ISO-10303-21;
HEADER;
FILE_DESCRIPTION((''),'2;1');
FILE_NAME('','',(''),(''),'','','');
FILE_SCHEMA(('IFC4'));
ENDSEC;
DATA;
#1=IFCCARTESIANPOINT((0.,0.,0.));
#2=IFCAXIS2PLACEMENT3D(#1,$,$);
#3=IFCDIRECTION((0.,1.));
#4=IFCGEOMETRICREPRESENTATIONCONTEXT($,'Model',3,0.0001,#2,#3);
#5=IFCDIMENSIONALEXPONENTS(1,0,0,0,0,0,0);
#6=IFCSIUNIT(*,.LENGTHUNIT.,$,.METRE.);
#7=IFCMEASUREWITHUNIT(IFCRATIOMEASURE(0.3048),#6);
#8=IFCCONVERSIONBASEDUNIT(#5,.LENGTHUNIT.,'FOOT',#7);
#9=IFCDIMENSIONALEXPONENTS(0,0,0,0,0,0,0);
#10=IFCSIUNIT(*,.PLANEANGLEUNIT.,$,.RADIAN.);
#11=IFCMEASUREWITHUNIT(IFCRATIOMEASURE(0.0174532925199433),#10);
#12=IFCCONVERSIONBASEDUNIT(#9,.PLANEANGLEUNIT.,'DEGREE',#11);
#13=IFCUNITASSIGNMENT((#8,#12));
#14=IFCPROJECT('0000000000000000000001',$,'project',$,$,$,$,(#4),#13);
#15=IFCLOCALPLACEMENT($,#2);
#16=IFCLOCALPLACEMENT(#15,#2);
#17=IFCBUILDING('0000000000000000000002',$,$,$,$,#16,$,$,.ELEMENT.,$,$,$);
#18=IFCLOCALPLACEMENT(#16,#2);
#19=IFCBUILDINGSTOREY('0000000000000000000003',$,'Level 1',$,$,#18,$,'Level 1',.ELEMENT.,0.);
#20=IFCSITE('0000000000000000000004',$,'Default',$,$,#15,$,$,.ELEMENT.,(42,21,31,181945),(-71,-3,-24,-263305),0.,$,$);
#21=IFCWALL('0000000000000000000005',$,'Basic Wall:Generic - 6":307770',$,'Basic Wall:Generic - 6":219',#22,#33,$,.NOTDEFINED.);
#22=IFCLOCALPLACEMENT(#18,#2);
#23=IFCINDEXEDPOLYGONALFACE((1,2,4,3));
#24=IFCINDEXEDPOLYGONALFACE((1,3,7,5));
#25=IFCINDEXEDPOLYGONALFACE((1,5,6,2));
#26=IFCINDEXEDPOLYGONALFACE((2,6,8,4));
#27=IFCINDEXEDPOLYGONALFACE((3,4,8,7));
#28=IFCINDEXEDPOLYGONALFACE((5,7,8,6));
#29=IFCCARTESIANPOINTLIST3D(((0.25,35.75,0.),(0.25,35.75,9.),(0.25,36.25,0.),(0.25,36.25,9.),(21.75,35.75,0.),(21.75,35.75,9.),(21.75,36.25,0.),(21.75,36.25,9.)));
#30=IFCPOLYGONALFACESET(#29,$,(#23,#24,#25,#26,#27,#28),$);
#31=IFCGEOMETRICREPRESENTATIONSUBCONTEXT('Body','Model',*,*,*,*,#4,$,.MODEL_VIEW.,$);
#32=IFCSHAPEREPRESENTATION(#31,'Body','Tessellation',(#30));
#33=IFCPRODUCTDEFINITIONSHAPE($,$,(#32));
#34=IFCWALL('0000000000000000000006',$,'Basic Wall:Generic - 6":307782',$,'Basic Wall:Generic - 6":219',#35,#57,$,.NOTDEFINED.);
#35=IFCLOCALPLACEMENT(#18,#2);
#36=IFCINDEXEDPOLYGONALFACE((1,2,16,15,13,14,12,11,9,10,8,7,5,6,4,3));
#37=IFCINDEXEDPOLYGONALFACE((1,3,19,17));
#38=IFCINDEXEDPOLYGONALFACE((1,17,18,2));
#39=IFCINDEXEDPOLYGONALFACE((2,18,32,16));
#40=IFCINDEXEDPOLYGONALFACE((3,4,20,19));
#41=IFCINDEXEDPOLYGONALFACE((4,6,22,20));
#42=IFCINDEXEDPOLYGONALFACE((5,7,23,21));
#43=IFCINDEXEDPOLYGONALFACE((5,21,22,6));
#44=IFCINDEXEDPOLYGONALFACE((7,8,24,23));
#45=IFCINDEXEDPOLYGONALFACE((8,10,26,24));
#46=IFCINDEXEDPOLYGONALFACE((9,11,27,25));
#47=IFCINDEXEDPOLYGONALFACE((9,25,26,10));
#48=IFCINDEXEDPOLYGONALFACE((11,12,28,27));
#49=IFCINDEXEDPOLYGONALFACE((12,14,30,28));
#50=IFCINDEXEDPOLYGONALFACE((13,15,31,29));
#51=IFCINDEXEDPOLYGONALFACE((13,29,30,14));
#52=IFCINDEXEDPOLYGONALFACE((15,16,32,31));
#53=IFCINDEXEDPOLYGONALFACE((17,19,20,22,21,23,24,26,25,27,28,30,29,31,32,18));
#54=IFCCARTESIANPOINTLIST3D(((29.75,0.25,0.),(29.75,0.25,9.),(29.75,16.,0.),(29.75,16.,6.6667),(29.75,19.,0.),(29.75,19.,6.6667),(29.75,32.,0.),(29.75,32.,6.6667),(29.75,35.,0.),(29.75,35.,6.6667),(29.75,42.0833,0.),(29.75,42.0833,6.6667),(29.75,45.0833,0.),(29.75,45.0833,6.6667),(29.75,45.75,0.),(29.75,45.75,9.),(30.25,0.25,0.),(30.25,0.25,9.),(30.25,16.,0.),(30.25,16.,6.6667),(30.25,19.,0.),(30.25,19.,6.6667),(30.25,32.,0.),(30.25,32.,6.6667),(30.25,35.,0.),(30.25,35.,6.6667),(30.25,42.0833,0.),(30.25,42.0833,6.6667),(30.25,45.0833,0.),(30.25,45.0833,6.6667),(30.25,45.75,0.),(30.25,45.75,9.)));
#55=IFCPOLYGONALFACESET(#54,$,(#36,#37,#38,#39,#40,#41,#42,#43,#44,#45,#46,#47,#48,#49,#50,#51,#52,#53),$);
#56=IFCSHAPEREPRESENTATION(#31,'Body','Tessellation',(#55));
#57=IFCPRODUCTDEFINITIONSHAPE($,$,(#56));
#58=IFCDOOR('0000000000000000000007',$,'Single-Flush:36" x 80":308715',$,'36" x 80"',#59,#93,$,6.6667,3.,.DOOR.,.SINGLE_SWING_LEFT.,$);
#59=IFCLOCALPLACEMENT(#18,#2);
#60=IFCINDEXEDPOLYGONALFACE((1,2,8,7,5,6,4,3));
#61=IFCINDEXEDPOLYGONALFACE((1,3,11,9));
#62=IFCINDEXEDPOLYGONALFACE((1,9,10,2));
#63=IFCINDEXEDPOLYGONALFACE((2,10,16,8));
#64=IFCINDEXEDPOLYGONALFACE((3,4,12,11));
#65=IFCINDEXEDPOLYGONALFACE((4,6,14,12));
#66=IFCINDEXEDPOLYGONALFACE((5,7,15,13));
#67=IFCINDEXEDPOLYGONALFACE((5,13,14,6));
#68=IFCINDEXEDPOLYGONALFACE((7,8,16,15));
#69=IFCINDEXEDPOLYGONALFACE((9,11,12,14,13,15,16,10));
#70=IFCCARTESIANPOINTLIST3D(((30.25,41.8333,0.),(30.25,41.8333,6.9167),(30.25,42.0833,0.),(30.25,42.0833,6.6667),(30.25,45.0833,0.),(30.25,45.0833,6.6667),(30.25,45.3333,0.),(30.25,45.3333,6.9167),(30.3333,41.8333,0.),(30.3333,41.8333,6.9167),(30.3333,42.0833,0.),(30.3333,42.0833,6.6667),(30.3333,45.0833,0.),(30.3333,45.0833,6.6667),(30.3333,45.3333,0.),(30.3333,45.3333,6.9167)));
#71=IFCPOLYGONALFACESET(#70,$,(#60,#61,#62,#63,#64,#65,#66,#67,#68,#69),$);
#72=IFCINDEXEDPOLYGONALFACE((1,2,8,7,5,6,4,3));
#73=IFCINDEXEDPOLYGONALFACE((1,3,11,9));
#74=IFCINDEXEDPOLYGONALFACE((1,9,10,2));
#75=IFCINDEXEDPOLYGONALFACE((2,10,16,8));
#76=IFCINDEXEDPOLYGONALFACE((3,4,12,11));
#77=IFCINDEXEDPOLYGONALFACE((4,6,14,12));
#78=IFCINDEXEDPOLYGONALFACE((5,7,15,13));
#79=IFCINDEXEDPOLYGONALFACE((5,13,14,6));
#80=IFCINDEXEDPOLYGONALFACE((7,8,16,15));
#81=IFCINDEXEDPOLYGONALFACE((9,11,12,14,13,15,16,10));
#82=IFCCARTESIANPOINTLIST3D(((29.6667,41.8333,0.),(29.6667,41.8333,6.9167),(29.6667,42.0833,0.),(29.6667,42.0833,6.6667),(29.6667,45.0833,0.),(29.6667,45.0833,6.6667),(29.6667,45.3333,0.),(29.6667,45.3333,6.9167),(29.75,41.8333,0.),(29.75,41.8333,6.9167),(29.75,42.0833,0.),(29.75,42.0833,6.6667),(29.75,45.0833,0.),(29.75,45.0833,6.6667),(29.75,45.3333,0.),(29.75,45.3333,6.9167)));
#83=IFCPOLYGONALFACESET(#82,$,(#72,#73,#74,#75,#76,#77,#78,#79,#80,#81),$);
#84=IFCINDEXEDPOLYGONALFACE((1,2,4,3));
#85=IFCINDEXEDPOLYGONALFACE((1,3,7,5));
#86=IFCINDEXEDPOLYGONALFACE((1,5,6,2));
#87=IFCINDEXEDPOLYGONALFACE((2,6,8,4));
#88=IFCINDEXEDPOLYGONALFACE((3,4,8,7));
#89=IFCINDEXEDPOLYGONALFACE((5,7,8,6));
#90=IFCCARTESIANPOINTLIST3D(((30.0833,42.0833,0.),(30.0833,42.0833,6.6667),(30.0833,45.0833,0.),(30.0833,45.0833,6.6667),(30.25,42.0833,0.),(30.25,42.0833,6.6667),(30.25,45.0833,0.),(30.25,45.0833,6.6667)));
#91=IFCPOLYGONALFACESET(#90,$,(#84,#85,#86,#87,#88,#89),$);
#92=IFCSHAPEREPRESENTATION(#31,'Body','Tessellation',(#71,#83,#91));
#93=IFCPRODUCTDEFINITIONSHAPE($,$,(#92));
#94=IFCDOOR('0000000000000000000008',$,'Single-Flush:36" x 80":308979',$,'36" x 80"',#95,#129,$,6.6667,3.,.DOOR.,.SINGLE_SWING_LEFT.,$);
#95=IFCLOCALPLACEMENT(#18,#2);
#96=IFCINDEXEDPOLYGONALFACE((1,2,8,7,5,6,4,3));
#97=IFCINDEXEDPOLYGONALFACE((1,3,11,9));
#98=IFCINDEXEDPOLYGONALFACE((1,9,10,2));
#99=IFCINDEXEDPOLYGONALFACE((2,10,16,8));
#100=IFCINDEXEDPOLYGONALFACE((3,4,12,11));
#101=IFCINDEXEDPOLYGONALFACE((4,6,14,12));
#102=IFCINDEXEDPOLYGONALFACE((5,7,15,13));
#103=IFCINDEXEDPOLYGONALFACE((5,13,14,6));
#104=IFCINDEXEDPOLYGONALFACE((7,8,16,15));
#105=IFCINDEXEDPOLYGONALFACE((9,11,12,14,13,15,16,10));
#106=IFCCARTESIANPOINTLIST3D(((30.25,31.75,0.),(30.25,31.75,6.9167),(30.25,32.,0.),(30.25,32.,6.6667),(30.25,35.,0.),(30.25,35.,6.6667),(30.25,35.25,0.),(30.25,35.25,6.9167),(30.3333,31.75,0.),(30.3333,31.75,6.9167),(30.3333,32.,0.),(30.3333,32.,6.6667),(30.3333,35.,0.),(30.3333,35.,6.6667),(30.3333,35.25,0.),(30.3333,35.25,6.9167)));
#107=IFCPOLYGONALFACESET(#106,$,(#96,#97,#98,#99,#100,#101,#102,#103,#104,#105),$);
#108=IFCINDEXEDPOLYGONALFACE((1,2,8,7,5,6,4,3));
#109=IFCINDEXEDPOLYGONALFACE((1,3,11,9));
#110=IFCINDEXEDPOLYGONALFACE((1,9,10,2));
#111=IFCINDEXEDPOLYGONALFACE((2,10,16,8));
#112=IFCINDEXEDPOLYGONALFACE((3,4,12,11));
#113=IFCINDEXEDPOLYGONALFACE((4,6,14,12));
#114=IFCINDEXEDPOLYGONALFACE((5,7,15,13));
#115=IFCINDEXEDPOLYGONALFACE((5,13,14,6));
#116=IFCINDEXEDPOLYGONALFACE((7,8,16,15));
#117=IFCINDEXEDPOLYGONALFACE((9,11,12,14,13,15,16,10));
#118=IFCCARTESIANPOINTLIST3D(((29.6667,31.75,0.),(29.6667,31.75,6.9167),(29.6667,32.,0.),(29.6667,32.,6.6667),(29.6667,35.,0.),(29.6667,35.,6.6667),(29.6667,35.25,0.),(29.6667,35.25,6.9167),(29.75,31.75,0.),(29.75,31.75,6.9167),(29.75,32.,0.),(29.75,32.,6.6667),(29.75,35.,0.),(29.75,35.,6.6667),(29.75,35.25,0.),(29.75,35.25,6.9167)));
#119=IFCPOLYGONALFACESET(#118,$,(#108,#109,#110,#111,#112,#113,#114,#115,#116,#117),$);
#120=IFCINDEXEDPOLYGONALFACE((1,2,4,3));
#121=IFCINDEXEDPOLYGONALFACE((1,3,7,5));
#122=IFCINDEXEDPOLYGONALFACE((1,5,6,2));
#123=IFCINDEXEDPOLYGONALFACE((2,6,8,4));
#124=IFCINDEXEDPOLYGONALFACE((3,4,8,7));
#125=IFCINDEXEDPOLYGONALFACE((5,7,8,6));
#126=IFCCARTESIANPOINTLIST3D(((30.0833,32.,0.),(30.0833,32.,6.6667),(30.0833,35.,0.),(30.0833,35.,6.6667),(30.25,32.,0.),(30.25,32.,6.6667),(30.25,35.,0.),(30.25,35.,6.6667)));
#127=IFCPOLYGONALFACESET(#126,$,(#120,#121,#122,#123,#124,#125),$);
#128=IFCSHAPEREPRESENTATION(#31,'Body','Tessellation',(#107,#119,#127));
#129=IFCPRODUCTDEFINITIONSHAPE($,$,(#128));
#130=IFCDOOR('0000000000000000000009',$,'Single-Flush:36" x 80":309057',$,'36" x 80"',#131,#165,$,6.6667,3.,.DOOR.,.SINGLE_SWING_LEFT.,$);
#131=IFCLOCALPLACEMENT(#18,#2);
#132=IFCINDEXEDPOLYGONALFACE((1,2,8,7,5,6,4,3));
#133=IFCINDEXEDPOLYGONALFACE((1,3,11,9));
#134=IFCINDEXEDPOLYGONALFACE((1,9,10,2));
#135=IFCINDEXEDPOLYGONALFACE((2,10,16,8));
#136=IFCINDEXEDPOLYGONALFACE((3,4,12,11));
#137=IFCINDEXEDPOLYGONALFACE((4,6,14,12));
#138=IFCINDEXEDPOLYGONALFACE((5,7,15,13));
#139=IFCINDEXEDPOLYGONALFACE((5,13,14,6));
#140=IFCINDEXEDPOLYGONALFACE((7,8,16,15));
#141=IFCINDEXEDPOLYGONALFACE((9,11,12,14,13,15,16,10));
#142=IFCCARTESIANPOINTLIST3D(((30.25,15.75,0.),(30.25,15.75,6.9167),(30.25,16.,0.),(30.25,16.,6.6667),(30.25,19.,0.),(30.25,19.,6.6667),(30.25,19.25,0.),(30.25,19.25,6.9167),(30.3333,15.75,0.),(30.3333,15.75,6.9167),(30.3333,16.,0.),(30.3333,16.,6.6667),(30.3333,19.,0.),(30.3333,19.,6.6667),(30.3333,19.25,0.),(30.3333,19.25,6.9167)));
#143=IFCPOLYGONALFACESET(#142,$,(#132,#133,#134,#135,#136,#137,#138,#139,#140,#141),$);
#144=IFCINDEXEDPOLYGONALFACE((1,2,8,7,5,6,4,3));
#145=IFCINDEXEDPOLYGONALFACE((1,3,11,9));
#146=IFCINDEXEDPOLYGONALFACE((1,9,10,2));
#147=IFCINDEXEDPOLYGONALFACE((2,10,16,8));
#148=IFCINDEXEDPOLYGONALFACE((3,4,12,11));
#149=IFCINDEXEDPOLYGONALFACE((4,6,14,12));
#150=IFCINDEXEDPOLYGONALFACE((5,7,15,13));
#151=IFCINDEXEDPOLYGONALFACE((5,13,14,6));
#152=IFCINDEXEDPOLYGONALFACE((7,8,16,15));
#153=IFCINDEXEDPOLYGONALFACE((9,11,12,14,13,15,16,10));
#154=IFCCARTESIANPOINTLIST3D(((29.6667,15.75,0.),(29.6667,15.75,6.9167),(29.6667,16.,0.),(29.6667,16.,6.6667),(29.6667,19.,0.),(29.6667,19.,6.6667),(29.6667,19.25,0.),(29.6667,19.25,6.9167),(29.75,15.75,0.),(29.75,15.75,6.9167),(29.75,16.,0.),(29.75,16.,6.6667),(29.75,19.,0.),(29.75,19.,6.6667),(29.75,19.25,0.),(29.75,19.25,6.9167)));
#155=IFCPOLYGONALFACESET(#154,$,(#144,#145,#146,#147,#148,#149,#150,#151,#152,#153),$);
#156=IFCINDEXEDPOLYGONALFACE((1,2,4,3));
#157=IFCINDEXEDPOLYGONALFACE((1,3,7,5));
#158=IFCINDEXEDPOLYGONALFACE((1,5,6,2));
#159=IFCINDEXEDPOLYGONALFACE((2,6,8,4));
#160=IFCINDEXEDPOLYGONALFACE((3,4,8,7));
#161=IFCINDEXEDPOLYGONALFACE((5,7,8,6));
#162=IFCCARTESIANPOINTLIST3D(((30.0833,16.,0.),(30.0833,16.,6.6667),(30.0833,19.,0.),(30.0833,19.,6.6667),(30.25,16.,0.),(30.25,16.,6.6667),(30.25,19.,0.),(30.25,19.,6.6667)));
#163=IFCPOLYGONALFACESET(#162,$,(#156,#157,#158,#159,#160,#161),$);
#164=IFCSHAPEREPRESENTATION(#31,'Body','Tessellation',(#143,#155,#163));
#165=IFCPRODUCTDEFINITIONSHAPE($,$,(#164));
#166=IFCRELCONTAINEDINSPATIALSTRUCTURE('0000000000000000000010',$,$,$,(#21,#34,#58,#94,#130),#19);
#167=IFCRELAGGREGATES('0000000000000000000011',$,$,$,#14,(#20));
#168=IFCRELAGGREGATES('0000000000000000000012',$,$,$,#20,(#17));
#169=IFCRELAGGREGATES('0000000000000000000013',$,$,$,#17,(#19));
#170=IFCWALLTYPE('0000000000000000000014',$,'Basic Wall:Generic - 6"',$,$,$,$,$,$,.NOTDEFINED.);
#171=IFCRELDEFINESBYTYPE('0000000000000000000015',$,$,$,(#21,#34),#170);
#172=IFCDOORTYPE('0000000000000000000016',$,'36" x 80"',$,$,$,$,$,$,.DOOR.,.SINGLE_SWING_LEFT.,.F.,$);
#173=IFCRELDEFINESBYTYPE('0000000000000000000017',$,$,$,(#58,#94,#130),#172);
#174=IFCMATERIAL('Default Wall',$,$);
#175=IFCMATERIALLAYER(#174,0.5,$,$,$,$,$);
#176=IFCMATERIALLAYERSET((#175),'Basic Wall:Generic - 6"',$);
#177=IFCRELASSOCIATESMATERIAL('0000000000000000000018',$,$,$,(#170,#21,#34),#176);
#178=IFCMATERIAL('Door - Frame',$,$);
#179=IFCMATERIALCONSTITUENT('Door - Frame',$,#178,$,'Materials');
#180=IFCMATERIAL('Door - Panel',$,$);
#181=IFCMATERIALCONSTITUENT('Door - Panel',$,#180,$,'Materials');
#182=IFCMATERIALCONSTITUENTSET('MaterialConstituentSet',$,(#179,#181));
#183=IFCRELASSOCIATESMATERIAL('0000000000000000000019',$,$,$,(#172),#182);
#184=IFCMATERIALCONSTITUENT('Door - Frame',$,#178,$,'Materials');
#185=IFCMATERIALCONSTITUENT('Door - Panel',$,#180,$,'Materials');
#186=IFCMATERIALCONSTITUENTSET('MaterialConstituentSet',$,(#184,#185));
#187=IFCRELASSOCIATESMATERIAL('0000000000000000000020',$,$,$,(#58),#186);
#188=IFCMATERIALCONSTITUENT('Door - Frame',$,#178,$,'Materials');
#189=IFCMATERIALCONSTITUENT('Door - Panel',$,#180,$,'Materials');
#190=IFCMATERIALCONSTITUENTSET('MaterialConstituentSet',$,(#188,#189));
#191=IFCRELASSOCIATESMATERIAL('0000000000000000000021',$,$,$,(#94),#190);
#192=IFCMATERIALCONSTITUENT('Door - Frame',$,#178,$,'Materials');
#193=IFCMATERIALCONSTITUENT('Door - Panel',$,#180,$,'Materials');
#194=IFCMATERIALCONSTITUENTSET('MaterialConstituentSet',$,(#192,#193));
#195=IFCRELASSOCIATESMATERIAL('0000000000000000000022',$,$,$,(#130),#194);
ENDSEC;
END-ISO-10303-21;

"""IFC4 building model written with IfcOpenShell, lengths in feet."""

from ifc_helpers import new_model, entity, si_unit, converted_unit, direction, frame, frame_2d, origin, origin_2d_with_axis, place, context, subcontext, project, spatial, polyline, rectangle, outline, extrude, clip, bounded_halfspace, source, transform, mapped, material, layer, layer_set, layer_usage, constituent, constituent_set, type_object, type_shapes, element, fill, save


model = new_model("IFC4")

# Units and contexts
model_context = context("Model", 3, precision=0.0001, world=origin(), true_north=direction((0.0, 1.0)))
body_context = subcontext(model_context, "Body", "Model", "MODEL_VIEW")
ifc_project = project(units=[converted_unit("LENGTHUNIT", "FOOT", entity("IfcRatioMeasure", 0.3048), si_unit("LENGTHUNIT", "METRE"), dimensions=[1, 0, 0, 0, 0, 0, 0]), converted_unit("PLANEANGLEUNIT", "DEGREE", entity("IfcRatioMeasure", 0.0174532925199433), si_unit("PLANEANGLEUNIT", "RADIAN"), dimensions=[0, 0, 0, 0, 0, 0, 0])], contexts=[model_context])

# Site, building, storey
site_placement = place(None, origin())
site = spatial("IfcSite", under=ifc_project, at=site_placement, Name="Default", CompositionType="ELEMENT", RefLatitude=(42, 21, 31, 181945), RefLongitude=(-71, -3, -24, -263305), RefElevation=0.0)
building_placement = place(site_placement, origin())
building = spatial("IfcBuilding", under=site, at=building_placement, CompositionType="ELEMENT")
storey_placement = place(building_placement, origin())
storey = spatial("IfcBuildingStorey", under=building, at=storey_placement, Name="Level 1", LongName="Level 1", CompositionType="ELEMENT", Elevation=0.0)

# Shared definitions
ifc_material_1 = material(Name="Default Wall")
ifc_layer = layer(ifc_material_1, 0.5)
ifc_layer_set = layer_set([ifc_layer], Name="Basic Wall:Generic - 6\"")
wall_type = type_object("IfcWallType", Name="Basic Wall:Generic - 6\"", PredefinedType="NOTDEFINED", material=ifc_layer_set)
ifc_material_2 = material(Name="Door - Frame")
ifc_material_3 = material(Name="Door - Panel")

# Wall
ifc_layer_usage_1 = layer_usage(ifc_layer_set, "AXIS2", "NEGATIVE", 0.25)
wall_1_placement = place(storey_placement, frame((0.25, 36.0, 0.0)))
element("IfcWall", 1, at=wall_1_placement, inside=storey, type_object=wall_type, material=ifc_layer_usage_1, Name="Basic Wall:Generic - 6\":307770", ObjectType="Basic Wall:Generic - 6\":219", PredefinedType="NOTDEFINED", context=body_context, shape_type="SweptSolid", body=[
    extrude(rectangle(XDim=21.5, YDim=0.5, at=frame_2d((10.75, 0.0), x_axis=(-1.0, 0.0))), origin(), (0.0, 0.0, 1.0), 9.0),
])

# Wall, openings, doors
ifc_layer_usage_2 = layer_usage(ifc_layer_set, "AXIS2", "NEGATIVE", 0.25)
wall_2_placement = place(storey_placement, frame((30.0, 45.75, 0.0), z_axis=(0.0, 0.0, 1.0), x_axis=(0.0, -1.0, 0.0)))
wall_2 = element("IfcWall", 2, at=wall_2_placement, inside=storey, type_object=wall_type, material=ifc_layer_usage_2, Name="Basic Wall:Generic - 6\":307782", ObjectType="Basic Wall:Generic - 6\":219", PredefinedType="NOTDEFINED", context=body_context, shape_type="Clipping", body=[
    clip(extrude(rectangle(XDim=45.5, YDim=0.5, at=frame_2d((22.75, 0.0), x_axis=(-1.0, 0.0))), origin(), (0.0, 0.0, 1.0), 9.0), bounded_halfspace(frame((25.5, -0.25, 9.0), z_axis=(0.0, 0.0, -1.0), x_axis=(-1.0, 0.0, 0.0)), True, frame((25.5, -0.25, 9.0)), polyline([(0.0, 0.0), (0.0, 0.5), (-15.5, 0.5), (-16.0, 0.5), (-25.5, 0.5), (-25.5, 0.0), (0.0, 0.0)]))),
])
opening_1_placement = place(wall_2_placement, frame((0.6667, -0.25, 0.0)))
opening_1 = element("IfcOpeningElement", 3, at=opening_1_placement, cuts=wall_2, ObjectType="Opening", PredefinedType="OPENING", context=body_context, shape_type="SweptSolid", body=[
    extrude(rectangle(XDim=3.0, YDim=6.6667, at=frame_2d((3.3333, 1.5), x_axis=(0.0, -1.0))), frame((0.0, 0.0, 0.0), z_axis=(0.0, 1.0, 0.0), x_axis=(0.0, 0.0, 1.0)), (0.0, 0.0, 1.0), 0.5),
])
opening_2_placement = place(wall_2_placement, frame((10.75, -0.25, 0.0)))
opening_2 = element("IfcOpeningElement", 4, at=opening_2_placement, cuts=wall_2, ObjectType="Opening", PredefinedType="OPENING", context=body_context, shape_type="SweptSolid", body=[
    extrude(rectangle(XDim=3.0, YDim=6.6667, at=frame_2d((3.3333, 1.5), x_axis=(0.0, -1.0))), frame((0.0, 0.0, 0.0), z_axis=(0.0, 1.0, 0.0), x_axis=(0.0, 0.0, 1.0)), (0.0, 0.0, 1.0), 0.5),
])
opening_3_placement = place(wall_2_placement, frame((26.75, -0.25, 0.0)))
opening_3 = element("IfcOpeningElement", 5, at=opening_3_placement, cuts=wall_2, ObjectType="Opening", PredefinedType="OPENING", context=body_context, shape_type="SweptSolid", body=[
    extrude(rectangle(XDim=3.0, YDim=6.6667, at=frame_2d((3.3333, 1.5), x_axis=(0.0, -1.0))), frame((0.0, 0.0, 0.0), z_axis=(0.0, 1.0, 0.0), x_axis=(0.0, 0.0, 1.0)), (0.0, 0.0, 1.0), 0.5),
])
ifc_constituent_1 = constituent(ifc_material_2, Name="Door - Frame", Category="Materials")
ifc_constituent_2 = constituent(ifc_material_3, Name="Door - Panel", Category="Materials")
ifc_constituent_set_1 = constituent_set(constituents=[ifc_constituent_1, ifc_constituent_2], Name="MaterialConstituentSet")
ifc_constituent_3 = constituent(ifc_material_2, Name="Door - Frame", Category="Materials")
ifc_constituent_4 = constituent(ifc_material_3, Name="Door - Panel", Category="Materials")
ifc_constituent_set_2 = constituent_set(constituents=[ifc_constituent_3, ifc_constituent_4], Name="MaterialConstituentSet")
door_type_1 = type_object("IfcDoorType", Name="36\" x 80\"", OperationType="SINGLE_SWING_LEFT", ParameterTakesPrecedence=False, PredefinedType="DOOR", material=ifc_constituent_set_2)
shared_shape_1 = source(origin(), body_context, "Body", "SweptSolid", [
    extrude(outline(polyline([(-1.75, -3.5208), (1.75, -3.5208), (1.75, 3.3958), (1.5, 3.3958), (1.5, -3.2708), (-1.5, -3.2708), (-1.5, 3.3958), (-1.75, 3.3958), (-1.75, -3.5208)])), frame((1.5, 0.5833, 3.3958), z_axis=(0.0, -1.0, 0.0), x_axis=(-1.0, 0.0, 0.0)), (0.0, 0.0, 1.0), 0.0833),
    extrude(outline(polyline([(-3.5208, -1.75), (3.3958, -1.75), (3.3958, -1.5), (-3.2708, -1.5), (-3.2708, 1.5), (3.3958, 1.5), (3.3958, 1.75), (-3.5208, 1.75), (-3.5208, -1.75)])), frame((1.5, 0.0, 3.3958), z_axis=(0.0, -1.0, 0.0), x_axis=(0.0, 0.0, -1.0)), (0.0, 0.0, 1.0), 0.0833),
    extrude(rectangle(XDim=3.0, YDim=0.1667, at=origin_2d_with_axis()), frame((1.5, 0.4167, 0.0)), (0.0, 0.0, 1.0), 6.6667),
])
type_shapes(door_type_1, [shared_shape_1])
door_1_placement = place(opening_1_placement, origin())
door_1 = element("IfcDoor", 6, at=door_1_placement, inside=storey, type_object=door_type_1, material=ifc_constituent_set_1, Name="Single-Flush:36\" x 80\":308715", ObjectType="36\" x 80\"", OperationType="SINGLE_SWING_LEFT", OverallHeight=6.6667, OverallWidth=3.0, PredefinedType="DOOR", context=body_context, shape_type="MappedRepresentation", body=[
    mapped(shared_shape_1, transform((0.0, 0.0, 0.0), scale=1.0)),
])
fill(opening_1, door_1)
ifc_constituent_5 = constituent(ifc_material_2, Name="Door - Frame", Category="Materials")
ifc_constituent_6 = constituent(ifc_material_3, Name="Door - Panel", Category="Materials")
ifc_constituent_set_3 = constituent_set(constituents=[ifc_constituent_5, ifc_constituent_6], Name="MaterialConstituentSet")
door_2_placement = place(opening_2_placement, origin())
door_2 = element("IfcDoor", 7, at=door_2_placement, inside=storey, type_object=door_type_1, material=ifc_constituent_set_3, Name="Single-Flush:36\" x 80\":308979", ObjectType="36\" x 80\"", OperationType="SINGLE_SWING_LEFT", OverallHeight=6.6667, OverallWidth=3.0, PredefinedType="DOOR", context=body_context, shape_type="MappedRepresentation", body=[
    mapped(shared_shape_1, transform((0.0, 0.0, 0.0), scale=1.0)),
])
fill(opening_2, door_2)
ifc_constituent_7 = constituent(ifc_material_2, Name="Door - Frame", Category="Materials")
ifc_constituent_8 = constituent(ifc_material_3, Name="Door - Panel", Category="Materials")
ifc_constituent_set_4 = constituent_set(constituents=[ifc_constituent_7, ifc_constituent_8], Name="MaterialConstituentSet")
door_3_placement = place(opening_3_placement, origin())
door_3 = element("IfcDoor", 8, at=door_3_placement, inside=storey, type_object=door_type_1, material=ifc_constituent_set_4, Name="Single-Flush:36\" x 80\":309057", ObjectType="36\" x 80\"", OperationType="SINGLE_SWING_LEFT", OverallHeight=6.6667, OverallWidth=3.0, PredefinedType="DOOR", context=body_context, shape_type="MappedRepresentation", body=[
    mapped(shared_shape_1, transform((0.0, 0.0, 0.0), scale=1.0)),
])
fill(opening_3, door_3)

save(model, "model.ifc")
